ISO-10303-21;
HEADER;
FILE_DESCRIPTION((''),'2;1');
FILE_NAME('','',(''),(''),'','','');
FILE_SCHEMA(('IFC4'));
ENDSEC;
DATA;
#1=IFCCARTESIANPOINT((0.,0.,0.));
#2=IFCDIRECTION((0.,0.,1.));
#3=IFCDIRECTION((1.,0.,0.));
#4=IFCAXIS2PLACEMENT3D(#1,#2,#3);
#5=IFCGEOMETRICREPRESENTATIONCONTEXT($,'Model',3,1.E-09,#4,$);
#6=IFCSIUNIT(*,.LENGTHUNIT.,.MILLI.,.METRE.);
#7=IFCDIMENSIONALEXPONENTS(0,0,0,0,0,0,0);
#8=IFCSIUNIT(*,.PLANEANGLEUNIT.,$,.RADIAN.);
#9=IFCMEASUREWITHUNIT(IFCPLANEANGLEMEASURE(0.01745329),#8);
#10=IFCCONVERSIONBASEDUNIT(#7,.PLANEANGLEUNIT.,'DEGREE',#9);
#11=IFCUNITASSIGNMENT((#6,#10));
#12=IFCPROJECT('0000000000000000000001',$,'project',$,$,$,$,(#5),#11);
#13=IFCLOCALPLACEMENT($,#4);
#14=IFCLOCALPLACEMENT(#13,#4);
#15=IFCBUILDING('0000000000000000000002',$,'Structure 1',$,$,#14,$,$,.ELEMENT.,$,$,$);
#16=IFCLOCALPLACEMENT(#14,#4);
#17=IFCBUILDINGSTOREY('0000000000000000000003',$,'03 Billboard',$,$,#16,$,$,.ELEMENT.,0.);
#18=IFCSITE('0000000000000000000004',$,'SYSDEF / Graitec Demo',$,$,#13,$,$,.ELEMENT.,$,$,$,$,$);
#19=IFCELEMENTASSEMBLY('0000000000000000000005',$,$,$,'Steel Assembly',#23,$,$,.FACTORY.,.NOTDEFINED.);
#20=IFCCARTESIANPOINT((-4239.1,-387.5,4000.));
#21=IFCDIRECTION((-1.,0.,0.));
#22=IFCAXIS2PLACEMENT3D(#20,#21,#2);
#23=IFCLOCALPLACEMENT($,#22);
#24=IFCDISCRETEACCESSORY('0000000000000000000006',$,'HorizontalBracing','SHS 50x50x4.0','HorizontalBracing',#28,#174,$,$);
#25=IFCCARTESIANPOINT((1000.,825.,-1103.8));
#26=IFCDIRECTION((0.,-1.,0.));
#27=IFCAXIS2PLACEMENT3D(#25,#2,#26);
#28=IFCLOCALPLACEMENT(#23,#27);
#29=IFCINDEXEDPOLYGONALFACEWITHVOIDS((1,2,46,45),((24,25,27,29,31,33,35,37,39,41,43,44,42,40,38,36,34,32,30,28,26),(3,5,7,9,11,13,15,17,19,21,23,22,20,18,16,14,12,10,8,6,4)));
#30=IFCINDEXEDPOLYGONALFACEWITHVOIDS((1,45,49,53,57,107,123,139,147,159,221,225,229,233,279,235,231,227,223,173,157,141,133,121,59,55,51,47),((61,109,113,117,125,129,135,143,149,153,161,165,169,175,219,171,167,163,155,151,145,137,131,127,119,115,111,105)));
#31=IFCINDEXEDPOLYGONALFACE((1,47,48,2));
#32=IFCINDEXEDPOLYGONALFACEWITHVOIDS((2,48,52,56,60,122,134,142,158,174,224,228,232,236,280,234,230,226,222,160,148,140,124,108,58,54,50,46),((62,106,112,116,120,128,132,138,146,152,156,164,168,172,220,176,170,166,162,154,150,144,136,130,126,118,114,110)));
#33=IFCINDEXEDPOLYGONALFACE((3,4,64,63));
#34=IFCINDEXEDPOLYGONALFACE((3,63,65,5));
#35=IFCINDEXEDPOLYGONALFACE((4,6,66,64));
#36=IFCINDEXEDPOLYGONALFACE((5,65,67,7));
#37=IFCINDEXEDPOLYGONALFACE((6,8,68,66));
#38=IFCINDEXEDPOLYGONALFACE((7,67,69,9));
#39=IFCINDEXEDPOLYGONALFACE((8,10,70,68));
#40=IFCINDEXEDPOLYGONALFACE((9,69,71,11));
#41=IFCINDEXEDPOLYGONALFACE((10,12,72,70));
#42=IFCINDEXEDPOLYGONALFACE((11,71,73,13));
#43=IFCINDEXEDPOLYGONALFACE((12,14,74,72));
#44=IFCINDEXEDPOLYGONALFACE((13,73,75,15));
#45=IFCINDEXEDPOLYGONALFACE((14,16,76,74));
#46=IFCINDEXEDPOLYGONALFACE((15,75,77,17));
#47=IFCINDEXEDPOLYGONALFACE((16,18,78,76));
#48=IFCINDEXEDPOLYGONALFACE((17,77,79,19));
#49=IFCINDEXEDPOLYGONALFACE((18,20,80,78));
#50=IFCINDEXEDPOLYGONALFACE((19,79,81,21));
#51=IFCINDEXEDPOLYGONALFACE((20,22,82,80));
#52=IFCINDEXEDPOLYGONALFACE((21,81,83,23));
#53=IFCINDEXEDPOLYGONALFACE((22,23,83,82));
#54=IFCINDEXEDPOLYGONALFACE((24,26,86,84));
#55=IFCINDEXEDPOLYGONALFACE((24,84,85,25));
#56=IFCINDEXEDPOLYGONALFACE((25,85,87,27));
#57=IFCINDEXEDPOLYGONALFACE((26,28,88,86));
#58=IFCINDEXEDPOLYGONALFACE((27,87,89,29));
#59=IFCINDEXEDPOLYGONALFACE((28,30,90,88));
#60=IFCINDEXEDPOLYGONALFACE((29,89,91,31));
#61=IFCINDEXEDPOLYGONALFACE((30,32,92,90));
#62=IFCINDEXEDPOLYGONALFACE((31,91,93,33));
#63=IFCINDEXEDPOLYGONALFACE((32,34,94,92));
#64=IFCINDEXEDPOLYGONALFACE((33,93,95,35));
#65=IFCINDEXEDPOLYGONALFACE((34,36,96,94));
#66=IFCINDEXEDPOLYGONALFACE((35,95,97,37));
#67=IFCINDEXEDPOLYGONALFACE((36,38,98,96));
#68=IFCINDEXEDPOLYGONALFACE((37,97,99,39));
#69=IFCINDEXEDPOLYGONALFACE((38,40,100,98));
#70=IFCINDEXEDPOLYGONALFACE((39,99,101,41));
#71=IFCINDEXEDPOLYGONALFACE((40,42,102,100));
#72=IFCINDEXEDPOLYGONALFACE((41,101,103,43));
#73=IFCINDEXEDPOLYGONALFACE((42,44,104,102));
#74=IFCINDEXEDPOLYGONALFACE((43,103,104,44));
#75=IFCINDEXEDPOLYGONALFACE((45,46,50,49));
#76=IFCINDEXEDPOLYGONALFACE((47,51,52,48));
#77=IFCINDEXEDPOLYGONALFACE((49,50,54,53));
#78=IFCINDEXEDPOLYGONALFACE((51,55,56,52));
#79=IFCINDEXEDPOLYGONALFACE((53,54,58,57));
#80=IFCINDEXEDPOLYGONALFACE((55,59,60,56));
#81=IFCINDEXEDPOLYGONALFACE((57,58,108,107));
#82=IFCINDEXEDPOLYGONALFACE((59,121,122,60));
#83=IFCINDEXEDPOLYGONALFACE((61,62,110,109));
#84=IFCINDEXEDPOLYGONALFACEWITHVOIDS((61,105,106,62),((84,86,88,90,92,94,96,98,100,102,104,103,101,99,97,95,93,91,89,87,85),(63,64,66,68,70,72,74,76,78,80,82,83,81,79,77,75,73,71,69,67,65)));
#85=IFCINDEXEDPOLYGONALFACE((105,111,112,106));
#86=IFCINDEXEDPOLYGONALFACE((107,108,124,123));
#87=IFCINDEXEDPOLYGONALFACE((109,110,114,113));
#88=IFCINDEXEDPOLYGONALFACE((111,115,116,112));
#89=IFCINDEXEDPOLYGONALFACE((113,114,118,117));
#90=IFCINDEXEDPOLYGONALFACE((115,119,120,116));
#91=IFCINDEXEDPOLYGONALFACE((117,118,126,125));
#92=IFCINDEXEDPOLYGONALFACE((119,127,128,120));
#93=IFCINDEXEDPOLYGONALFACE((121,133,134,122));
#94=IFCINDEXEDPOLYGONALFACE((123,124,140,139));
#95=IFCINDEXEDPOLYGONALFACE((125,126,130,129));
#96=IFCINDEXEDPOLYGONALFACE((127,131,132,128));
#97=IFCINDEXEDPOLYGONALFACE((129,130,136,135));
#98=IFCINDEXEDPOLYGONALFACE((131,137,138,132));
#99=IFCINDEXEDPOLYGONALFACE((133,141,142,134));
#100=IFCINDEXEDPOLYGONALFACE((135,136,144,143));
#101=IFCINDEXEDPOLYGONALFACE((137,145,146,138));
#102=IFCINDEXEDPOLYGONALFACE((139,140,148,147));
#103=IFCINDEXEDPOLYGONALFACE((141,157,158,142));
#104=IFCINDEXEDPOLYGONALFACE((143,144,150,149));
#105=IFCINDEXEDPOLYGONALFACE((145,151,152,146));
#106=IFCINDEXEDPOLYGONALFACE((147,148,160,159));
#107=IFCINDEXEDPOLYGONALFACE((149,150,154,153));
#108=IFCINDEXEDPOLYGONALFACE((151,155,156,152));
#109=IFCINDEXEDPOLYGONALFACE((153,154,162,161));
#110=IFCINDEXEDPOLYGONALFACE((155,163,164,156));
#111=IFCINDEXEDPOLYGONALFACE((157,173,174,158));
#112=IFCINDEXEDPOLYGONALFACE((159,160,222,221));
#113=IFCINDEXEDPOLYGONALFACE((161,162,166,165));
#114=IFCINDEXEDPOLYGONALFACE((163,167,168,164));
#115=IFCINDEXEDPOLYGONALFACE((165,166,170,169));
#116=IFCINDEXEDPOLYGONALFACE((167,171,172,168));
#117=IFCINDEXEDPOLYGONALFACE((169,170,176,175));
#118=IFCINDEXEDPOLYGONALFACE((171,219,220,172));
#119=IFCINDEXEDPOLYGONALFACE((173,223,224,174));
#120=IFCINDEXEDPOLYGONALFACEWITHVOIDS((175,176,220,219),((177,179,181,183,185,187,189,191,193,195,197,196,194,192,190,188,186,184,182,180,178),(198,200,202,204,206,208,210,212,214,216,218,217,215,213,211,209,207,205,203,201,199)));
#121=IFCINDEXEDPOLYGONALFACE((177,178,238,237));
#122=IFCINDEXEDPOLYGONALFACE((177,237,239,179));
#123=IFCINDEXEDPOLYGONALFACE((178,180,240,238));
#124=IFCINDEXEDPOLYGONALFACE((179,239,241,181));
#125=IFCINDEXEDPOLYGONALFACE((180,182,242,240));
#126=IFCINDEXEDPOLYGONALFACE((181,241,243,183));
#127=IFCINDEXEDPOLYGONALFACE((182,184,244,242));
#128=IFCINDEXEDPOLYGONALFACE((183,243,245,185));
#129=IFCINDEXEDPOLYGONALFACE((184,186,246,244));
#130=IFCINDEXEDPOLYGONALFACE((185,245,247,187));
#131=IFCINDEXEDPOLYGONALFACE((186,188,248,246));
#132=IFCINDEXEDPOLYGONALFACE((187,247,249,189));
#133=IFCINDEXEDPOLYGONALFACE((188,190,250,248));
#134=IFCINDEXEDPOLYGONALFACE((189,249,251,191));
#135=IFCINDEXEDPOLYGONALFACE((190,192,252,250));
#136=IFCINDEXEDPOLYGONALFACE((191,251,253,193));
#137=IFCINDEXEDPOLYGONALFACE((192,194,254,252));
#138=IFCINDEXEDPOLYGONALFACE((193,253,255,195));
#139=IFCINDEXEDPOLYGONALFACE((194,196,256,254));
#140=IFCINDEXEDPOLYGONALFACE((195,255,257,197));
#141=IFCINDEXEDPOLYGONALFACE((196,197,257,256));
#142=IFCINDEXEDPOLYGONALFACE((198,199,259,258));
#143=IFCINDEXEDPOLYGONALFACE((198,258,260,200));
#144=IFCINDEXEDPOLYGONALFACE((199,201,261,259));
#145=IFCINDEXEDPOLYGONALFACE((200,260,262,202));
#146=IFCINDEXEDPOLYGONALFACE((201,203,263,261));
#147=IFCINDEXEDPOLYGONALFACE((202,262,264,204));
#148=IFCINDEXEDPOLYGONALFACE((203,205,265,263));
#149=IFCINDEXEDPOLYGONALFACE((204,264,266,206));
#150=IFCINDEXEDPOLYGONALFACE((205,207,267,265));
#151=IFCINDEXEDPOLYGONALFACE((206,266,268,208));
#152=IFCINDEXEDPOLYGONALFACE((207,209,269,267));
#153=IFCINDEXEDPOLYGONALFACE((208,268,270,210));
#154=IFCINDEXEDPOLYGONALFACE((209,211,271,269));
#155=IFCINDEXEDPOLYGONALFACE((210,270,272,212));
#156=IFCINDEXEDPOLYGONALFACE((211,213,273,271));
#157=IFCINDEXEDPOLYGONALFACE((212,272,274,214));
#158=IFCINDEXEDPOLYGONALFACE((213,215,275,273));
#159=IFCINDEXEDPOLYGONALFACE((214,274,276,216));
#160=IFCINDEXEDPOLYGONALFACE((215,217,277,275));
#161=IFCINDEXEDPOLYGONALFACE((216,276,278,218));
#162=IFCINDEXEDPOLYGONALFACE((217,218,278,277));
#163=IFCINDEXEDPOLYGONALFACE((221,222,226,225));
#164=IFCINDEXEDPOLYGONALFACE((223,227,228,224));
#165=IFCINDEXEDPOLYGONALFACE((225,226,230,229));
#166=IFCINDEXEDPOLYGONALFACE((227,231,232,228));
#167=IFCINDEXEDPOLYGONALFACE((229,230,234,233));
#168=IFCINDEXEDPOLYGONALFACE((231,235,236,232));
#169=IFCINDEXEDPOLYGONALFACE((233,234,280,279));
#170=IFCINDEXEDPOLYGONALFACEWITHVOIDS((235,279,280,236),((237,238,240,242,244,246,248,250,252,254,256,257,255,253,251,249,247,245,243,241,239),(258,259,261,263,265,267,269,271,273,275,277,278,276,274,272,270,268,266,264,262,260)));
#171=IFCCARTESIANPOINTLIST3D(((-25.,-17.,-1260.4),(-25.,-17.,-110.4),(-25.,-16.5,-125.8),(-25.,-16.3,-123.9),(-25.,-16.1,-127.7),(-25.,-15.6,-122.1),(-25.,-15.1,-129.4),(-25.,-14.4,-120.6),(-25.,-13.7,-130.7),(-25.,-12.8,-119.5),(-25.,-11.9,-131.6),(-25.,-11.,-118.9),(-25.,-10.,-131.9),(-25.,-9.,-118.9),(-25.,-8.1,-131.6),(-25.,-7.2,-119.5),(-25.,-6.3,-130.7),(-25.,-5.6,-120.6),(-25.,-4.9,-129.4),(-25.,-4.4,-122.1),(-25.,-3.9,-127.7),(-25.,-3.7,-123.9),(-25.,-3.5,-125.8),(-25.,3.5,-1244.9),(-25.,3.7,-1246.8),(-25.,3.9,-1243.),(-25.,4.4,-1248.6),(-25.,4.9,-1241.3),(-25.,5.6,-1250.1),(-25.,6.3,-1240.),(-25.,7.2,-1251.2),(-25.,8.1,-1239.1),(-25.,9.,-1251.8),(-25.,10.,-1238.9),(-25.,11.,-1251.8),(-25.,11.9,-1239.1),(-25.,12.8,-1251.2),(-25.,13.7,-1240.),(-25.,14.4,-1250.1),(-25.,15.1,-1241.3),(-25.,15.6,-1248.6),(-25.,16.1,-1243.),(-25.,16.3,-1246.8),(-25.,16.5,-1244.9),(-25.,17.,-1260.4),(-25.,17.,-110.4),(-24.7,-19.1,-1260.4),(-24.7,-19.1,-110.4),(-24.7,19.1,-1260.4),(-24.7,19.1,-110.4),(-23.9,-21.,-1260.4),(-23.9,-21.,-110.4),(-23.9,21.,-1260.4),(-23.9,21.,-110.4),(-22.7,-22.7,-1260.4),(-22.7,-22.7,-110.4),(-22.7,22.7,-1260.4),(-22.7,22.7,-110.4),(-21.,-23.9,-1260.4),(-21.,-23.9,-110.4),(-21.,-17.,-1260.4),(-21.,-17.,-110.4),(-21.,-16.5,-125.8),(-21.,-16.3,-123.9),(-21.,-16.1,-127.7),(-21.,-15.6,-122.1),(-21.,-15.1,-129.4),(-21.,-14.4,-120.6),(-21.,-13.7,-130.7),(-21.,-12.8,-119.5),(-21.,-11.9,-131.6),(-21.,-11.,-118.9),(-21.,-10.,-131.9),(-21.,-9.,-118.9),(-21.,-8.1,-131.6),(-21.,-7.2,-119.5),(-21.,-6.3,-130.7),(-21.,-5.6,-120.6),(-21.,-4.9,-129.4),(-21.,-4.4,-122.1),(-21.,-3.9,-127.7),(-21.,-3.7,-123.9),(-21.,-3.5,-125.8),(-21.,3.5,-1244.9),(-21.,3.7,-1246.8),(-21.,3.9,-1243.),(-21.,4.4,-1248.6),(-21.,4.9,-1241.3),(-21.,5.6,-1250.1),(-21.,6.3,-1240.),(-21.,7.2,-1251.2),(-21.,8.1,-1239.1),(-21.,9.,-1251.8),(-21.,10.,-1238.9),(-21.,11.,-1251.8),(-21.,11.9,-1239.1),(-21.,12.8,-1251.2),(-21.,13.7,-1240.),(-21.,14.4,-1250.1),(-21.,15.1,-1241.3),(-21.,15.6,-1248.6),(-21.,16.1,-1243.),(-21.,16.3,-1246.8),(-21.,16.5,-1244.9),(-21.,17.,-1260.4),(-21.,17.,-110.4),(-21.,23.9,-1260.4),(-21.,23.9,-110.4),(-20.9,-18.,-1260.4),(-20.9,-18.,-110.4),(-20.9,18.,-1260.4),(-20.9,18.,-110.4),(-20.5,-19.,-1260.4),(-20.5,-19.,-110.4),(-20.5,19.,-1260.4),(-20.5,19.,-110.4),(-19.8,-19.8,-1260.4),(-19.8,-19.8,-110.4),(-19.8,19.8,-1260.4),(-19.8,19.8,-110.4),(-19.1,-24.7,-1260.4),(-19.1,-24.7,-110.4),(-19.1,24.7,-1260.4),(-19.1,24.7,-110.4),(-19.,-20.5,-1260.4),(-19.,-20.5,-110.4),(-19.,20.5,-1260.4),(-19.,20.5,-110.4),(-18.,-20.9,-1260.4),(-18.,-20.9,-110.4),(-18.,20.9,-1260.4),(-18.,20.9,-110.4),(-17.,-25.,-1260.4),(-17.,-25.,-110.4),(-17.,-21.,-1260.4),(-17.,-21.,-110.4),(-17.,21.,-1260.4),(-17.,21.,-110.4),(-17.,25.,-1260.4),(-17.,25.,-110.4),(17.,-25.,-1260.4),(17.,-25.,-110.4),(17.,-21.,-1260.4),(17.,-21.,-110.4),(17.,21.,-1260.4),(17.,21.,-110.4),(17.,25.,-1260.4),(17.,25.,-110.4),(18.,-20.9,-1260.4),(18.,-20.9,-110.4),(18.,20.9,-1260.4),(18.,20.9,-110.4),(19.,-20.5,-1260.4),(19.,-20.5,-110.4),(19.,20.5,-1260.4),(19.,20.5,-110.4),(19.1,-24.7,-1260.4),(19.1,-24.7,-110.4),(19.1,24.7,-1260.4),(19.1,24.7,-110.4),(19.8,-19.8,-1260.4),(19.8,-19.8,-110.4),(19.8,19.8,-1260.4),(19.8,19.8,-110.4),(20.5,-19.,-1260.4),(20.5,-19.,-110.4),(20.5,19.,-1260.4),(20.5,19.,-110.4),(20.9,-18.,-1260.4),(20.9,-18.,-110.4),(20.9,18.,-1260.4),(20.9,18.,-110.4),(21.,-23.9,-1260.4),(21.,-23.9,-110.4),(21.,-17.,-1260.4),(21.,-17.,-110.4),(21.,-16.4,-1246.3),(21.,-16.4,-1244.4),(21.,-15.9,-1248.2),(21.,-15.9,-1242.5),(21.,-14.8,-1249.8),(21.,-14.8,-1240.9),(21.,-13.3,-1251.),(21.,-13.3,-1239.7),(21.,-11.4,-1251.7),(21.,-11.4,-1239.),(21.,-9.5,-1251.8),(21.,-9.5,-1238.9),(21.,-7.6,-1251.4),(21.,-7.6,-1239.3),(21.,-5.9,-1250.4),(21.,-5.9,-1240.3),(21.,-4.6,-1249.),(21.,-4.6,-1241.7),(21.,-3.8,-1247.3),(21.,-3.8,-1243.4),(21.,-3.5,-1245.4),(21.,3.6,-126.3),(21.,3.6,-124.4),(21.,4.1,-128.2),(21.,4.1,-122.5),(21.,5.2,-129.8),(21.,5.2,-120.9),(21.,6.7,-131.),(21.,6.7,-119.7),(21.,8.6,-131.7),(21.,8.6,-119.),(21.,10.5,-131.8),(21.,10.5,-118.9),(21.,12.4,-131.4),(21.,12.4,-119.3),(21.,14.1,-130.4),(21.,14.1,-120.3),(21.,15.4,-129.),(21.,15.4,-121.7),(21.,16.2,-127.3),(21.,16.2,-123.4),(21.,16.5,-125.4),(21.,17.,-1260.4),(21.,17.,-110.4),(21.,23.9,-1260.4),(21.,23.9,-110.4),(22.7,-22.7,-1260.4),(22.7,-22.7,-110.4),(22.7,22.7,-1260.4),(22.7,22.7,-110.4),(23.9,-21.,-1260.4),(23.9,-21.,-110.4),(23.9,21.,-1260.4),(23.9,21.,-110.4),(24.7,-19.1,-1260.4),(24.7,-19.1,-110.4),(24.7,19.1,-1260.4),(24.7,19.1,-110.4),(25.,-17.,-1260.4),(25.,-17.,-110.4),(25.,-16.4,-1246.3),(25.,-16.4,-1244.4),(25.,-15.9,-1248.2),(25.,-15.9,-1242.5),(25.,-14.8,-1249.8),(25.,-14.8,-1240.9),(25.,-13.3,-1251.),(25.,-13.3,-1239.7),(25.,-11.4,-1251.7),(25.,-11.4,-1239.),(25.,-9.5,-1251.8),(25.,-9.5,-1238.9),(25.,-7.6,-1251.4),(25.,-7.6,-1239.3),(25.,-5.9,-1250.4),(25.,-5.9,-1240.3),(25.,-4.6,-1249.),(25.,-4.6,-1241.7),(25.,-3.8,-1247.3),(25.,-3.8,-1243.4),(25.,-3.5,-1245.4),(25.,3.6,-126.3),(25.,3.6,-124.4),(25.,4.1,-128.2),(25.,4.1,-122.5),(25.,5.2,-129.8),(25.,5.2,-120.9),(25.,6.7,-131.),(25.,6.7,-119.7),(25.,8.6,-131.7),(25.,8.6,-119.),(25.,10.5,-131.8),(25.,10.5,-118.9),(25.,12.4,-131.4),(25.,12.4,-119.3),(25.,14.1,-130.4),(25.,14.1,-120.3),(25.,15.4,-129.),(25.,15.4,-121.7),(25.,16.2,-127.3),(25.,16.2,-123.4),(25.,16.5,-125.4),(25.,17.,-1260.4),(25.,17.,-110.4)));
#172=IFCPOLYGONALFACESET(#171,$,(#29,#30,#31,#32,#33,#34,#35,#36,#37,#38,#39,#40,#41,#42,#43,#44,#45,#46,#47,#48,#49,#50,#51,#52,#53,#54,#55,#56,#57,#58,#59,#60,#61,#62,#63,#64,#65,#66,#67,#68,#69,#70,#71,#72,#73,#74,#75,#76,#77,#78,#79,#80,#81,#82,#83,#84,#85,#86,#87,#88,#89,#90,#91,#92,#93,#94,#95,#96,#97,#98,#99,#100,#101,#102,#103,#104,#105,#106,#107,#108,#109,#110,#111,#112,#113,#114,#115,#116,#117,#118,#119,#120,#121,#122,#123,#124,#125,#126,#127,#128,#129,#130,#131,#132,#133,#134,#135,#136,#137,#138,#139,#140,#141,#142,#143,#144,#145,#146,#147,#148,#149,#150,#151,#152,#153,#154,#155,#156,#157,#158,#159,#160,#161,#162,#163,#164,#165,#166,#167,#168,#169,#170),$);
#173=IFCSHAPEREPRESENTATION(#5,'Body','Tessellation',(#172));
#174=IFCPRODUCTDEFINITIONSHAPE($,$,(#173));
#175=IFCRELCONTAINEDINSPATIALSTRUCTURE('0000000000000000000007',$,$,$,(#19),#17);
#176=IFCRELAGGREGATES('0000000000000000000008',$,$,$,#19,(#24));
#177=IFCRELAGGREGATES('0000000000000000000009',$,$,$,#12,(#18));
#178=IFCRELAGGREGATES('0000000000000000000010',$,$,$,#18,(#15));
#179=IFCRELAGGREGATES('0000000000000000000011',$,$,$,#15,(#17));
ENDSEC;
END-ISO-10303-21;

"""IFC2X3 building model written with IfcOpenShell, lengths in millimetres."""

from ifc_helpers import new_model, entity, si_unit, converted_unit, frame, frame_2d, origin, origin_with_axes, origin_2d, origin_2d_with_axis, place, context, project, spatial, hollow_rectangle, circle, extrude, clip, halfspace, element, aggregate, save


model = new_model("IFC2X3")

# Units and contexts
model_context = context("Model", 3, precision=1e-09, world=origin_with_axes())
ifc_project = project(units=[si_unit("LENGTHUNIT", "METRE", prefix="MILLI"), converted_unit("PLANEANGLEUNIT", "DEGREE", entity("IfcPlaneAngleMeasure", 0.01745329), si_unit("PLANEANGLEUNIT", "RADIAN"), dimensions=[0, 0, 0, 0, 0, 0, 0])], contexts=[model_context])

# Site, building, storey
site_placement = place(None, origin_with_axes())
site = spatial("IfcSite", under=ifc_project, at=site_placement, Name="SYSDEF / Graitec Demo", CompositionType="ELEMENT")
building_placement = place(site_placement, origin_with_axes())
building = spatial("IfcBuilding", under=site, at=building_placement, Name="Structure 1", CompositionType="ELEMENT")
storey_placement = place(building_placement, origin_with_axes())
storey = spatial("IfcBuildingStorey", under=building, at=storey_placement, Name="03 Billboard", CompositionType="ELEMENT", Elevation=0.0)

# Element assembly, discrete accessory, openings
assembly_1_placement = place(None, frame((-4239.1, -387.5, 4000.0), z_axis=(-1.0, 0.0, 0.0), x_axis=(0.0, 0.0, 1.0)))
assembly_1 = element("IfcElementAssembly", 1, at=assembly_1_placement, inside=storey, ObjectType="Steel Assembly", AssemblyPlace="FACTORY", PredefinedType="NOTDEFINED")
discrete_accessory_1_placement = place(assembly_1_placement, frame((1000.0, 825.0, -1103.8), z_axis=(0.0, 0.0, 1.0), x_axis=(0.0, -1.0, 0.0)))
discrete_accessory_1 = element("IfcDiscreteAccessory", 2, at=discrete_accessory_1_placement, Name="HorizontalBracing", Description="SHS 50x50x4.0", ObjectType="HorizontalBracing", context=model_context, shape_type="Clipping", body=[
    clip(clip(extrude(hollow_rectangle(XDim=50.0, YDim=50.0, WallThickness=4.0, InnerFilletRadius=4.0, OuterFilletRadius=8.0, at=origin_2d()), origin(), (0.0, 0.0, -1.0), 1370.7), halfspace(frame((437.5, -5000.0, -1260.4), z_axis=(0.0, 0.0, 1.0), x_axis=(1.0, 0.0, 0.0)), True)), halfspace(frame((437.5, -5000.0, -110.4), z_axis=(0.0, 0.0, -1.0), x_axis=(-1.0, 0.0, 0.0)), True)),
])
opening_1_placement = place(discrete_accessory_1_placement, frame((-20.5, -10.0, -125.4), z_axis=(-1.0, 0.0, 0.0), x_axis=(0.0, 0.0, -1.0)))
element("IfcOpeningElement", 3, at=opening_1_placement, cuts=discrete_accessory_1, ObjectType="Opening", context=model_context, shape_type="SweptSolid", body=[
    extrude(circle(Radius=6.5, at=origin_2d_with_axis()), origin(), (0.0, 0.0, 1.0), 5.0),
])
opening_2_placement = place(discrete_accessory_1_placement, frame((25.5, 10.0, -118.9), z_axis=(1.0, 0.0, 0.0), x_axis=(0.0, 1.0, 0.0)))
element("IfcOpeningElement", 4, at=opening_2_placement, cuts=discrete_accessory_1, ObjectType="Opening", context=model_context, shape_type="SweptSolid", body=[
    extrude(circle(Radius=6.5, at=frame_2d((0.0, -6.5), x_axis=(1.0, 0.0))), origin(), (0.0, 0.0, -1.0), 5.0),
])
opening_3_placement = place(discrete_accessory_1_placement, frame((-20.5, 10.0, -1245.4), z_axis=(-1.0, 0.0, 0.0), x_axis=(0.0, 0.0, 1.0)))
element("IfcOpeningElement", 5, at=opening_3_placement, cuts=discrete_accessory_1, ObjectType="Opening", context=model_context, shape_type="SweptSolid", body=[
    extrude(circle(Radius=6.5, at=origin_2d_with_axis()), origin(), (0.0, 0.0, 1.0), 5.0),
])
opening_4_placement = place(discrete_accessory_1_placement, frame((25.5, -10.0, -1251.9), z_axis=(1.0, 0.0, 0.0), x_axis=(0.0, 1.0, 0.0)))
element("IfcOpeningElement", 6, at=opening_4_placement, cuts=discrete_accessory_1, ObjectType="Opening", context=model_context, shape_type="SweptSolid", body=[
    extrude(circle(Radius=6.5, at=frame_2d((0.0, 6.5), x_axis=(1.0, 0.0))), origin(), (0.0, 0.0, -1.0), 5.0),
])
aggregate(assembly_1, [discrete_accessory_1])

save(model, "model.ifc")
